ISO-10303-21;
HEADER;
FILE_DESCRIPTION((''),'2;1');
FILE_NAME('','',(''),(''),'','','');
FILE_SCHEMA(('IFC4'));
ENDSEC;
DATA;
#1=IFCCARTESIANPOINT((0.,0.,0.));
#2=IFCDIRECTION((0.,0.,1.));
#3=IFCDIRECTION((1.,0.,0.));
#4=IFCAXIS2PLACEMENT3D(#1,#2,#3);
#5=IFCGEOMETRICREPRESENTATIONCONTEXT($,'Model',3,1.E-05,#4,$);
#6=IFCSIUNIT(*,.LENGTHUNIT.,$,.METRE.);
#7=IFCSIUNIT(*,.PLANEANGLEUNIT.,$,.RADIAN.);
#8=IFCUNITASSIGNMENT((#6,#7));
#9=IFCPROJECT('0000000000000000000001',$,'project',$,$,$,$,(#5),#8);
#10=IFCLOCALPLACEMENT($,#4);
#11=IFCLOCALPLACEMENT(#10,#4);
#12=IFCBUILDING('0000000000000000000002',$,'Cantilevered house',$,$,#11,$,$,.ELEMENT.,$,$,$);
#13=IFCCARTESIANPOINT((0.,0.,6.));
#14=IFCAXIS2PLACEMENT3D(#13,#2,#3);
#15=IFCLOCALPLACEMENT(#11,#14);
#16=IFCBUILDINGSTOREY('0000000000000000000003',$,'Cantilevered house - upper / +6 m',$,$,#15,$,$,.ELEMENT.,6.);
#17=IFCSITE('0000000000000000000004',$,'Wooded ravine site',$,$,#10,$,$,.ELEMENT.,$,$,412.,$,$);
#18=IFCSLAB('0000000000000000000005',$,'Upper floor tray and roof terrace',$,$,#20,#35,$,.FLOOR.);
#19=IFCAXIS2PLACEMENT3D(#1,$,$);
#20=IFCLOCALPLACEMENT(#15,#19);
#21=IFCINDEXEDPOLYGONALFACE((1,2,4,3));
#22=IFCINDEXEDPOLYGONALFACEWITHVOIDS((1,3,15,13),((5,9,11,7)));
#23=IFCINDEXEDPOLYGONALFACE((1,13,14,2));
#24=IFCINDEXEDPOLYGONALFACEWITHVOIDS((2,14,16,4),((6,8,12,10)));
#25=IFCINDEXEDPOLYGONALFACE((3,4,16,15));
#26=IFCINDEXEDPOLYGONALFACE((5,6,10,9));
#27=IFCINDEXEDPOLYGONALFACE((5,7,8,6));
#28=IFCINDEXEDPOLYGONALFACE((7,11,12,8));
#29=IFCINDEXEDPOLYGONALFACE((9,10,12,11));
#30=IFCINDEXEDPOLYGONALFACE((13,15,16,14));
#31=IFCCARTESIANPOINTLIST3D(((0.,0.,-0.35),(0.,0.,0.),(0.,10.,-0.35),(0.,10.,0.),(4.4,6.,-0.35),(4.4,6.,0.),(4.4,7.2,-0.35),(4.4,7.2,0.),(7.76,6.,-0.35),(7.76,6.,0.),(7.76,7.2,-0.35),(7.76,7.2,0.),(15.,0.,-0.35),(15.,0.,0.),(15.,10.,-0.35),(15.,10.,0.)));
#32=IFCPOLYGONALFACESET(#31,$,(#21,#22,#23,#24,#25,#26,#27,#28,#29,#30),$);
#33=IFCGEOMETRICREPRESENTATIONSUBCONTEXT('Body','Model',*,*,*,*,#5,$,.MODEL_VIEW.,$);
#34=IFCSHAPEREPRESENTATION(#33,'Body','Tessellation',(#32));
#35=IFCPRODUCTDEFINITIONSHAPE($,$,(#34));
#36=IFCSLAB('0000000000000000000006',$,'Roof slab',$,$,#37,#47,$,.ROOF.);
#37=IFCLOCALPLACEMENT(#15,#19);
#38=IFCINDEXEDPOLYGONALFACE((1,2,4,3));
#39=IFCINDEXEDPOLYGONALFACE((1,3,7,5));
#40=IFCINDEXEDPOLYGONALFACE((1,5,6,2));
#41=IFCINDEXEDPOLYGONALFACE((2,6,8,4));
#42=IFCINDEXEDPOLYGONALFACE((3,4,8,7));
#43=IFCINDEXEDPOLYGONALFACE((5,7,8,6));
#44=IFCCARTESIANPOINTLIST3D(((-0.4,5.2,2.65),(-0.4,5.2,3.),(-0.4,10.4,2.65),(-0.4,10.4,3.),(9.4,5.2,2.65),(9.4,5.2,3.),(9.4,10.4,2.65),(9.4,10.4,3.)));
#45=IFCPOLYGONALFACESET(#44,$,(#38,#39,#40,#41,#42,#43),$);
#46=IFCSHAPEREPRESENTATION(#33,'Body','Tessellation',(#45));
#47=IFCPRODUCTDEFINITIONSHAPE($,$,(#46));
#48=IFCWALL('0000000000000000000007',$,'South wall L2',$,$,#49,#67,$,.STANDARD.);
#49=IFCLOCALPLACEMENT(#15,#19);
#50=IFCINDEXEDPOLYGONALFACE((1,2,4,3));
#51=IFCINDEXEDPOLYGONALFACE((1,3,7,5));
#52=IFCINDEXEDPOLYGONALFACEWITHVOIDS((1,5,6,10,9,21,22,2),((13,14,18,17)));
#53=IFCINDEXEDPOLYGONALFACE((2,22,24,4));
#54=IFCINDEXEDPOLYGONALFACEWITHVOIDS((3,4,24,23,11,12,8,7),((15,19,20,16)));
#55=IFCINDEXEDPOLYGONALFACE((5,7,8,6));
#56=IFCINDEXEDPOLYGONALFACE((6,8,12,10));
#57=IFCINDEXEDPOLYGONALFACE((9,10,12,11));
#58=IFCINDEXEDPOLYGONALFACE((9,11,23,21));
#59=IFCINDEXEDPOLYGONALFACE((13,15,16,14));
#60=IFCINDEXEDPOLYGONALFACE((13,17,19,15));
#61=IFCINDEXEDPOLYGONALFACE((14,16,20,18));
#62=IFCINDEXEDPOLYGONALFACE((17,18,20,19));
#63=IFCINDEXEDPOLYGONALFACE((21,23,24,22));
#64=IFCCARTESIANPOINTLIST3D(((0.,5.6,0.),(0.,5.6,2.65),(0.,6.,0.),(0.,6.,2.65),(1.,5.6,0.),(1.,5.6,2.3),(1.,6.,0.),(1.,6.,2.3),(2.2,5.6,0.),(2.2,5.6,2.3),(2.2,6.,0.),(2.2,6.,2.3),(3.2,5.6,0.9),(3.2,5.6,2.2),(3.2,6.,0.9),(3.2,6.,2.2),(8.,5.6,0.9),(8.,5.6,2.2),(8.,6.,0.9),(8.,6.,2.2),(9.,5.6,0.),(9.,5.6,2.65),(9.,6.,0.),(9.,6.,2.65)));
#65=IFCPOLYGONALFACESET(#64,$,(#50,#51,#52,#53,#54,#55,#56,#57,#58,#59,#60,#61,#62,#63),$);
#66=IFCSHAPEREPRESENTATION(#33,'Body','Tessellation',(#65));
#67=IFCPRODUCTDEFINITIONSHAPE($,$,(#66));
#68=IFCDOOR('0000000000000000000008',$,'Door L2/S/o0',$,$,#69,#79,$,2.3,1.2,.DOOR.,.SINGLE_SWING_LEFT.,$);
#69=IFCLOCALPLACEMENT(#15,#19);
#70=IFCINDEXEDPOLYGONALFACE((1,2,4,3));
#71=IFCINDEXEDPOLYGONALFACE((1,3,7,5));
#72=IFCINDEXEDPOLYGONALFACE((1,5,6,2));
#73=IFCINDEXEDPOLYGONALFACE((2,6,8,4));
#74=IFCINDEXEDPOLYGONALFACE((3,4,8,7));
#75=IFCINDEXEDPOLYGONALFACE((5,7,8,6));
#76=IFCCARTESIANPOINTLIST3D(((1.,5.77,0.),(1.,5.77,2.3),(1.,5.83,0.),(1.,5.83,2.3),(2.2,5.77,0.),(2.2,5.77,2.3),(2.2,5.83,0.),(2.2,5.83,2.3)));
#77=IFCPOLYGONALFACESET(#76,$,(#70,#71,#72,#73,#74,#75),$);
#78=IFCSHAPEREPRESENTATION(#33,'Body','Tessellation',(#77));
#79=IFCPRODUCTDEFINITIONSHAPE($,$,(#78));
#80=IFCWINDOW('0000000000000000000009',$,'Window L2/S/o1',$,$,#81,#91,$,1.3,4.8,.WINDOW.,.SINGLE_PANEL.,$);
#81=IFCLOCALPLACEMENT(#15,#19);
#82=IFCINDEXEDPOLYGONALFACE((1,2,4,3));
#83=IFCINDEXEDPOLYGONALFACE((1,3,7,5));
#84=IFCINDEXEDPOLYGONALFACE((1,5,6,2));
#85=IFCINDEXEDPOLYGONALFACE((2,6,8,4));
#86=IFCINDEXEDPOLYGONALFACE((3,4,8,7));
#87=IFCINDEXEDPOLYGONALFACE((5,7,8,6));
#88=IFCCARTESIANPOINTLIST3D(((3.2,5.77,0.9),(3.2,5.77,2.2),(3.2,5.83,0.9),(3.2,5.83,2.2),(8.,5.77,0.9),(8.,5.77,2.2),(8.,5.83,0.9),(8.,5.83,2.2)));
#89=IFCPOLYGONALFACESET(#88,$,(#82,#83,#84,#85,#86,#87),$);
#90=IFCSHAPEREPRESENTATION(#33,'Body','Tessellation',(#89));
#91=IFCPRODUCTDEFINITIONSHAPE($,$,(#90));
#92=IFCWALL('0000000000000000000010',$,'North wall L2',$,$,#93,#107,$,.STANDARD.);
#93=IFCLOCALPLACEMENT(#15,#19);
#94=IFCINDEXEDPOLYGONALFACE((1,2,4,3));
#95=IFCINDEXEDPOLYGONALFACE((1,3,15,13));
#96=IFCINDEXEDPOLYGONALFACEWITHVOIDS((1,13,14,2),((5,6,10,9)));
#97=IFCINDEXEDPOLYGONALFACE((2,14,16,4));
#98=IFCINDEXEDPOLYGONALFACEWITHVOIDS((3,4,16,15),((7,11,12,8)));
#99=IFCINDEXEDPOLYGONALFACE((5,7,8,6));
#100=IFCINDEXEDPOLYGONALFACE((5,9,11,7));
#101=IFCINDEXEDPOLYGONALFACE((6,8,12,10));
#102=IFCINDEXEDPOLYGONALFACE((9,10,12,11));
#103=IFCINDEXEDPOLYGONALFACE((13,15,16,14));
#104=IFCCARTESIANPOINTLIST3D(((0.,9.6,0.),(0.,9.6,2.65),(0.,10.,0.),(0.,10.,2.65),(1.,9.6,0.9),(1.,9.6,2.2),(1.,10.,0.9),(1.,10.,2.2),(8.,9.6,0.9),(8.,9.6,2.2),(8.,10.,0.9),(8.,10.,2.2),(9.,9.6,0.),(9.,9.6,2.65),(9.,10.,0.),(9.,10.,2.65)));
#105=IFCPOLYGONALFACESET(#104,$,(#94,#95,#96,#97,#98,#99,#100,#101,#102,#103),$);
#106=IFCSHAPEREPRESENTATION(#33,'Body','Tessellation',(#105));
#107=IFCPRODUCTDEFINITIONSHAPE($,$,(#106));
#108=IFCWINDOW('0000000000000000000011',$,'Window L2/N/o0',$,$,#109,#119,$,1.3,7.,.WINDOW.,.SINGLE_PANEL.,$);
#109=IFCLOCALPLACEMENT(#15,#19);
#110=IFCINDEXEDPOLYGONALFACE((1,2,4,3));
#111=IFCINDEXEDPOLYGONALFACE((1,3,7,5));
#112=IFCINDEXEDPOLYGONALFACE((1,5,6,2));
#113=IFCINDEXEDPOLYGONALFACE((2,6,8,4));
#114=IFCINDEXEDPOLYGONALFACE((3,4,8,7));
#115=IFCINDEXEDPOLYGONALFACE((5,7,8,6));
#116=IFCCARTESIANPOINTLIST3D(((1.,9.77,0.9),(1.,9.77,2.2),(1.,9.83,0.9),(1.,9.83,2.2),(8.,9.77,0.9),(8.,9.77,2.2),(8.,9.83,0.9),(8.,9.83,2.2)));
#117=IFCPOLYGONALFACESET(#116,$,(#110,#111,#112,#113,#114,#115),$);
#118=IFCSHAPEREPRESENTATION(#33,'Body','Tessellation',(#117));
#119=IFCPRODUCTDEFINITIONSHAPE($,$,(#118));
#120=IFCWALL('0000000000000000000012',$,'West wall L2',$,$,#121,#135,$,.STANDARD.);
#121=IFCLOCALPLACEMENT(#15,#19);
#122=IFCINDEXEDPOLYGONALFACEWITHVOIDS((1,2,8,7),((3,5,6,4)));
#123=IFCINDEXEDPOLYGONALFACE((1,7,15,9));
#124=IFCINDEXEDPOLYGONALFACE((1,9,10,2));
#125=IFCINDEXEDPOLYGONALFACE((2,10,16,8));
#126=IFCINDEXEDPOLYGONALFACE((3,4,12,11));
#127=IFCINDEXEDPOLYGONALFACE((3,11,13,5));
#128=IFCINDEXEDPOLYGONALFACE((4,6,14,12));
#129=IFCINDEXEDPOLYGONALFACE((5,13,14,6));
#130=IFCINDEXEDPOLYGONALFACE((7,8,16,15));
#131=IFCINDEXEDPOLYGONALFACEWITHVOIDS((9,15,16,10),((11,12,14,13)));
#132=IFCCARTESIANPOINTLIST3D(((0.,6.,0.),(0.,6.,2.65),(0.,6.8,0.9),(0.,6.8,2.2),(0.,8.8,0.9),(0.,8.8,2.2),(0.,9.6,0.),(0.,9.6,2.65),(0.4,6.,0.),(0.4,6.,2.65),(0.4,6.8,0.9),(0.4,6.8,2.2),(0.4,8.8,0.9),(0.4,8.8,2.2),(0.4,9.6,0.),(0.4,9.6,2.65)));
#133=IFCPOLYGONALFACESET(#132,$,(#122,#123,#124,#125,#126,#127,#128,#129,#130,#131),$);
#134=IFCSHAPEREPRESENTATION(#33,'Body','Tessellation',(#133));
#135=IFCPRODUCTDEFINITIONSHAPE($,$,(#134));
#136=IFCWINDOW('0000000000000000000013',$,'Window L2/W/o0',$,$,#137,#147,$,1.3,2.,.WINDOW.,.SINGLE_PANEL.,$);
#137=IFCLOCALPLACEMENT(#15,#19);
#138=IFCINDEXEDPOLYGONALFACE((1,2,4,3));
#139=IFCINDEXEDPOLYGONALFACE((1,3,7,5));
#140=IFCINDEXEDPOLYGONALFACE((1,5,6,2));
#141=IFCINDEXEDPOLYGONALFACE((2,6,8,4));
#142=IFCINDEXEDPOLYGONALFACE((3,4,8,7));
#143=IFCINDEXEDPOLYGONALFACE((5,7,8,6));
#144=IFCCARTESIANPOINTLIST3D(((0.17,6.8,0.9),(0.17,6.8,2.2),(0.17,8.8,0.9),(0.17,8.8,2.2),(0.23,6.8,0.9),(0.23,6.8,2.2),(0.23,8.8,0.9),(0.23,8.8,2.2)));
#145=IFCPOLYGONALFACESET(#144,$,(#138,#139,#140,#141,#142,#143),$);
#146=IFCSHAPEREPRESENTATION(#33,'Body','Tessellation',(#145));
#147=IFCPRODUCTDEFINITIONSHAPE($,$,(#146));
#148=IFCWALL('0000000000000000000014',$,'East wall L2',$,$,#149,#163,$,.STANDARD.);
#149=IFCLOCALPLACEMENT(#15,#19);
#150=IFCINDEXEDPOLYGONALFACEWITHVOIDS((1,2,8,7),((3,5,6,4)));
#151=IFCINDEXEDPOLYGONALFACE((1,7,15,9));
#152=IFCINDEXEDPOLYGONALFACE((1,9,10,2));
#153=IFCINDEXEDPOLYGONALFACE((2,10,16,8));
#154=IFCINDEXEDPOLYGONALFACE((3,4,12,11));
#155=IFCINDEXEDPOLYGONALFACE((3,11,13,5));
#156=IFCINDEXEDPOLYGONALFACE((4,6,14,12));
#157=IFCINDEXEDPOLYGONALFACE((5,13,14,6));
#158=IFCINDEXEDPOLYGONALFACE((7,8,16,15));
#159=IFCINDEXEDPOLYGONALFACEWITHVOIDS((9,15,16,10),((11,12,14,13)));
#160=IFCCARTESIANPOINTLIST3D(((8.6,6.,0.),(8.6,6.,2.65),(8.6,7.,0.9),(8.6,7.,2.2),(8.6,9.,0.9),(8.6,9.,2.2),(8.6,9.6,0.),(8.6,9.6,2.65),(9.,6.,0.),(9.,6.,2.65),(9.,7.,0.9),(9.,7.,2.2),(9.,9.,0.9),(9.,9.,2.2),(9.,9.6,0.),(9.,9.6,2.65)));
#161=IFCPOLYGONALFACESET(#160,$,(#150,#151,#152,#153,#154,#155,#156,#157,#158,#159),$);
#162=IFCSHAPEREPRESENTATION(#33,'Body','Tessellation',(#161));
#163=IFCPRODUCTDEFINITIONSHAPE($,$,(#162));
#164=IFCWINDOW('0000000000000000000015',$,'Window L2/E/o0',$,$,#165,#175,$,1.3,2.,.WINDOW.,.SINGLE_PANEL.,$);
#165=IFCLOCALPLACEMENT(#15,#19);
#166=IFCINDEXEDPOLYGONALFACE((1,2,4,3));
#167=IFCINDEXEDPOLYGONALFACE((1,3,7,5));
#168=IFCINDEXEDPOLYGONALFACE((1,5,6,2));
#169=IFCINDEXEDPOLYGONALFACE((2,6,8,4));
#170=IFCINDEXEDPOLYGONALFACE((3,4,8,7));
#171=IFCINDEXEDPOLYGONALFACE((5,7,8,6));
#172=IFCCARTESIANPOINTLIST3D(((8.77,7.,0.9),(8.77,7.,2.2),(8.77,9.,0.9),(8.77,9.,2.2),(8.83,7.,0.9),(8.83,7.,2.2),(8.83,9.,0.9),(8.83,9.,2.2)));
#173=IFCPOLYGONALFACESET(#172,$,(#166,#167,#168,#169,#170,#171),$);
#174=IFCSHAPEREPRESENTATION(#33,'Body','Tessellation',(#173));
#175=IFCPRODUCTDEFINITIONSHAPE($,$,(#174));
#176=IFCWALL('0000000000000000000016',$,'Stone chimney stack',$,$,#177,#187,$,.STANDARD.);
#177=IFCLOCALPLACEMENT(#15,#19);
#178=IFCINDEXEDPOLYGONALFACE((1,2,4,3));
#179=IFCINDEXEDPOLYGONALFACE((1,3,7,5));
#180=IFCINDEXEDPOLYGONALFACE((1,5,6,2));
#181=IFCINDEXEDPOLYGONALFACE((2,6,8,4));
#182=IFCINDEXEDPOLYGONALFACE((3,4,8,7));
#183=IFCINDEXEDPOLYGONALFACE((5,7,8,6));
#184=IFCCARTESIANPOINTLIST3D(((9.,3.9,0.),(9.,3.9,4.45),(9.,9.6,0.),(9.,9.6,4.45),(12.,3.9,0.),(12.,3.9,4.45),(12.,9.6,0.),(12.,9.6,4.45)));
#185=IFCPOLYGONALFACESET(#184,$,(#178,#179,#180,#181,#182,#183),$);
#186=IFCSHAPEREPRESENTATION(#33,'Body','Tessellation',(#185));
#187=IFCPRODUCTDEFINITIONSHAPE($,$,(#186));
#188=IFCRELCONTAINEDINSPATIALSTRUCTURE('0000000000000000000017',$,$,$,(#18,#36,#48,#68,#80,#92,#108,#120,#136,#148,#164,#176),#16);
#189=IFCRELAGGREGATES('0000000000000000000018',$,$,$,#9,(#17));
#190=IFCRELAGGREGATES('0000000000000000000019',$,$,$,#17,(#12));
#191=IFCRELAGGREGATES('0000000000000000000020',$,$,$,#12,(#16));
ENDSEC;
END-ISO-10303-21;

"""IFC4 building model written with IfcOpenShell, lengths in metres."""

from ifc_helpers import new_model, si_unit, frame, frame_2d, origin_with_axes, place, context, subcontext, project, spatial, rectangle, extrude, element, fill, save


model = new_model("IFC4")

# Units and contexts
model_context = context("Model", 3, precision=1e-05, world=origin_with_axes())
body_context = subcontext(model_context, "Body", "Model", "MODEL_VIEW")
ifc_project = project(units=[si_unit("LENGTHUNIT", "METRE"), si_unit("PLANEANGLEUNIT", "RADIAN")], contexts=[model_context])

# Site, building, storey
site_placement = place(None, origin_with_axes())
site = spatial("IfcSite", under=ifc_project, at=site_placement, Name="Wooded ravine site", CompositionType="ELEMENT", RefElevation=412.0)
building_placement = place(site_placement, origin_with_axes())
building = spatial("IfcBuilding", under=site, at=building_placement, Name="Cantilevered house", CompositionType="ELEMENT")
storey_placement = place(building_placement, frame((0.0, 0.0, 6.0), z_axis=(0.0, 0.0, 1.0), x_axis=(1.0, 0.0, 0.0)))
storey = spatial("IfcBuildingStorey", under=building, at=storey_placement, Name="Cantilevered house - upper / +6 m", CompositionType="ELEMENT", Elevation=6.0)

# Slab, opening
slab_1_placement = place(storey_placement, origin_with_axes())
slab_1 = element("IfcSlab", 1, at=slab_1_placement, inside=storey, Name="Upper floor tray and roof terrace", PredefinedType="FLOOR", context=body_context, shape_type="SweptSolid", body=[
    extrude(rectangle(XDim=15.0, YDim=10.0, at=frame_2d((7.5, 5.0))), frame((0.0, 0.0, -0.35), z_axis=(0.0, 0.0, 1.0), x_axis=(1.0, 0.0, 0.0)), (0.0, 0.0, 1.0), 0.35),
])
opening_1_placement = place(storey_placement, origin_with_axes())
element("IfcOpeningElement", 2, at=opening_1_placement, inside=storey, cuts=slab_1, PredefinedType="OPENING", context=body_context, shape_type="SweptSolid", body=[
    extrude(rectangle(XDim=3.36, YDim=1.2, at=frame_2d((6.08, 6.6))), frame((0.0, 0.0, -0.37), z_axis=(0.0, 0.0, 1.0), x_axis=(1.0, 0.0, 0.0)), (0.0, 0.0, 1.0), 0.39),
])

# Slab
slab_2_placement = place(storey_placement, origin_with_axes())
element("IfcSlab", 3, at=slab_2_placement, inside=storey, Name="Roof slab", PredefinedType="ROOF", context=body_context, shape_type="SweptSolid", body=[
    extrude(rectangle(XDim=9.8, YDim=5.2, at=frame_2d((4.5, 7.8))), frame((0.0, 0.0, 2.65), z_axis=(0.0, 0.0, 1.0), x_axis=(1.0, 0.0, 0.0)), (0.0, 0.0, 1.0), 0.35),
])

# Wall, openings, door, window
wall_1_placement = place(storey_placement, origin_with_axes())
wall_1 = element("IfcWall", 4, at=wall_1_placement, inside=storey, Name="South wall L2", PredefinedType="STANDARD", context=body_context, shape_type="SweptSolid", body=[
    extrude(rectangle(XDim=9.0, YDim=0.4, at=frame_2d((4.5, 5.8))), origin_with_axes(), (0.0, 0.0, 1.0), 2.65),
])
opening_2_placement = place(storey_placement, origin_with_axes())
opening_2 = element("IfcOpeningElement", 5, at=opening_2_placement, inside=storey, cuts=wall_1, PredefinedType="OPENING", context=body_context, shape_type="SweptSolid", body=[
    extrude(rectangle(XDim=1.2, YDim=0.44, at=frame_2d((1.6, 5.8))), origin_with_axes(), (0.0, 0.0, 1.0), 2.3),
])
opening_3_placement = place(storey_placement, origin_with_axes())
opening_3 = element("IfcOpeningElement", 6, at=opening_3_placement, inside=storey, cuts=wall_1, PredefinedType="OPENING", context=body_context, shape_type="SweptSolid", body=[
    extrude(rectangle(XDim=4.8, YDim=0.44, at=frame_2d((5.6, 5.8))), frame((0.0, 0.0, 0.9), z_axis=(0.0, 0.0, 1.0), x_axis=(1.0, 0.0, 0.0)), (0.0, 0.0, 1.0), 1.3),
])
door_placement = place(storey_placement, origin_with_axes())
door = element("IfcDoor", 7, at=door_placement, inside=storey, Name="Door L2/S/o0", OperationType="SINGLE_SWING_LEFT", OverallHeight=2.3, OverallWidth=1.2, PredefinedType="DOOR", context=body_context, shape_type="SweptSolid", body=[
    extrude(rectangle(XDim=1.2, YDim=0.06, at=frame_2d((1.6, 5.8))), origin_with_axes(), (0.0, 0.0, 1.0), 2.3),
])
fill(opening_2, door)
window_1_placement = place(storey_placement, origin_with_axes())
window_1 = element("IfcWindow", 8, at=window_1_placement, inside=storey, Name="Window L2/S/o1", OverallHeight=1.3, OverallWidth=4.8, PartitioningType="SINGLE_PANEL", PredefinedType="WINDOW", context=body_context, shape_type="SweptSolid", body=[
    extrude(rectangle(XDim=4.8, YDim=0.06, at=frame_2d((5.6, 5.8))), frame((0.0, 0.0, 0.9), z_axis=(0.0, 0.0, 1.0), x_axis=(1.0, 0.0, 0.0)), (0.0, 0.0, 1.0), 1.3),
])
fill(opening_3, window_1)

# Walls, openings, windows
wall_2_placement = place(storey_placement, origin_with_axes())
wall_2 = element("IfcWall", 9, at=wall_2_placement, inside=storey, Name="North wall L2", PredefinedType="STANDARD", context=body_context, shape_type="SweptSolid", body=[
    extrude(rectangle(XDim=9.0, YDim=0.4, at=frame_2d((4.5, 9.8))), origin_with_axes(), (0.0, 0.0, 1.0), 2.65),
])
opening_4_placement = place(storey_placement, origin_with_axes())
opening_4 = element("IfcOpeningElement", 10, at=opening_4_placement, inside=storey, cuts=wall_2, PredefinedType="OPENING", context=body_context, shape_type="SweptSolid", body=[
    extrude(rectangle(XDim=7.0, YDim=0.44, at=frame_2d((4.5, 9.8))), frame((0.0, 0.0, 0.9), z_axis=(0.0, 0.0, 1.0), x_axis=(1.0, 0.0, 0.0)), (0.0, 0.0, 1.0), 1.3),
])
window_2_placement = place(storey_placement, origin_with_axes())
window_2 = element("IfcWindow", 11, at=window_2_placement, inside=storey, Name="Window L2/N/o0", OverallHeight=1.3, OverallWidth=7.0, PartitioningType="SINGLE_PANEL", PredefinedType="WINDOW", context=body_context, shape_type="SweptSolid", body=[
    extrude(rectangle(XDim=7.0, YDim=0.06, at=frame_2d((4.5, 9.8))), frame((0.0, 0.0, 0.9), z_axis=(0.0, 0.0, 1.0), x_axis=(1.0, 0.0, 0.0)), (0.0, 0.0, 1.0), 1.3),
])
fill(opening_4, window_2)
wall_3_placement = place(storey_placement, origin_with_axes())
wall_3 = element("IfcWall", 12, at=wall_3_placement, inside=storey, Name="West wall L2", PredefinedType="STANDARD", context=body_context, shape_type="SweptSolid", body=[
    extrude(rectangle(XDim=0.4, YDim=3.6, at=frame_2d((0.2, 7.8))), origin_with_axes(), (0.0, 0.0, 1.0), 2.65),
])
opening_5_placement = place(storey_placement, origin_with_axes())
opening_5 = element("IfcOpeningElement", 13, at=opening_5_placement, inside=storey, cuts=wall_3, PredefinedType="OPENING", context=body_context, shape_type="SweptSolid", body=[
    extrude(rectangle(XDim=0.44, YDim=2.0, at=frame_2d((0.2, 7.8))), frame((0.0, 0.0, 0.9), z_axis=(0.0, 0.0, 1.0), x_axis=(1.0, 0.0, 0.0)), (0.0, 0.0, 1.0), 1.3),
])
window_3_placement = place(storey_placement, origin_with_axes())
window_3 = element("IfcWindow", 14, at=window_3_placement, inside=storey, Name="Window L2/W/o0", OverallHeight=1.3, OverallWidth=2.0, PartitioningType="SINGLE_PANEL", PredefinedType="WINDOW", context=body_context, shape_type="SweptSolid", body=[
    extrude(rectangle(XDim=0.06, YDim=2.0, at=frame_2d((0.2, 7.8))), frame((0.0, 0.0, 0.9), z_axis=(0.0, 0.0, 1.0), x_axis=(1.0, 0.0, 0.0)), (0.0, 0.0, 1.0), 1.3),
])
fill(opening_5, window_3)
wall_4_placement = place(storey_placement, origin_with_axes())
wall_4 = element("IfcWall", 15, at=wall_4_placement, inside=storey, Name="East wall L2", PredefinedType="STANDARD", context=body_context, shape_type="SweptSolid", body=[
    extrude(rectangle(XDim=0.4, YDim=3.6, at=frame_2d((8.8, 7.8))), origin_with_axes(), (0.0, 0.0, 1.0), 2.65),
])
opening_6_placement = place(storey_placement, origin_with_axes())
opening_6 = element("IfcOpeningElement", 16, at=opening_6_placement, inside=storey, cuts=wall_4, PredefinedType="OPENING", context=body_context, shape_type="SweptSolid", body=[
    extrude(rectangle(XDim=0.44, YDim=2.0, at=frame_2d((8.8, 8.0))), frame((0.0, 0.0, 0.9), z_axis=(0.0, 0.0, 1.0), x_axis=(1.0, 0.0, 0.0)), (0.0, 0.0, 1.0), 1.3),
])
window_4_placement = place(storey_placement, origin_with_axes())
window_4 = element("IfcWindow", 17, at=window_4_placement, inside=storey, Name="Window L2/E/o0", OverallHeight=1.3, OverallWidth=2.0, PartitioningType="SINGLE_PANEL", PredefinedType="WINDOW", context=body_context, shape_type="SweptSolid", body=[
    extrude(rectangle(XDim=0.06, YDim=2.0, at=frame_2d((8.8, 8.0))), frame((0.0, 0.0, 0.9), z_axis=(0.0, 0.0, 1.0), x_axis=(1.0, 0.0, 0.0)), (0.0, 0.0, 1.0), 1.3),
])
fill(opening_6, window_4)

# Wall
wall_5_placement = place(storey_placement, origin_with_axes())
element("IfcWall", 18, at=wall_5_placement, inside=storey, Name="Stone chimney stack", PredefinedType="STANDARD", context=body_context, shape_type="SweptSolid", body=[
    extrude(rectangle(XDim=3.0, YDim=5.7, at=frame_2d((10.5, 6.75))), origin_with_axes(), (0.0, 0.0, 1.0), 4.45),
])

save(model, "model.ifc")
